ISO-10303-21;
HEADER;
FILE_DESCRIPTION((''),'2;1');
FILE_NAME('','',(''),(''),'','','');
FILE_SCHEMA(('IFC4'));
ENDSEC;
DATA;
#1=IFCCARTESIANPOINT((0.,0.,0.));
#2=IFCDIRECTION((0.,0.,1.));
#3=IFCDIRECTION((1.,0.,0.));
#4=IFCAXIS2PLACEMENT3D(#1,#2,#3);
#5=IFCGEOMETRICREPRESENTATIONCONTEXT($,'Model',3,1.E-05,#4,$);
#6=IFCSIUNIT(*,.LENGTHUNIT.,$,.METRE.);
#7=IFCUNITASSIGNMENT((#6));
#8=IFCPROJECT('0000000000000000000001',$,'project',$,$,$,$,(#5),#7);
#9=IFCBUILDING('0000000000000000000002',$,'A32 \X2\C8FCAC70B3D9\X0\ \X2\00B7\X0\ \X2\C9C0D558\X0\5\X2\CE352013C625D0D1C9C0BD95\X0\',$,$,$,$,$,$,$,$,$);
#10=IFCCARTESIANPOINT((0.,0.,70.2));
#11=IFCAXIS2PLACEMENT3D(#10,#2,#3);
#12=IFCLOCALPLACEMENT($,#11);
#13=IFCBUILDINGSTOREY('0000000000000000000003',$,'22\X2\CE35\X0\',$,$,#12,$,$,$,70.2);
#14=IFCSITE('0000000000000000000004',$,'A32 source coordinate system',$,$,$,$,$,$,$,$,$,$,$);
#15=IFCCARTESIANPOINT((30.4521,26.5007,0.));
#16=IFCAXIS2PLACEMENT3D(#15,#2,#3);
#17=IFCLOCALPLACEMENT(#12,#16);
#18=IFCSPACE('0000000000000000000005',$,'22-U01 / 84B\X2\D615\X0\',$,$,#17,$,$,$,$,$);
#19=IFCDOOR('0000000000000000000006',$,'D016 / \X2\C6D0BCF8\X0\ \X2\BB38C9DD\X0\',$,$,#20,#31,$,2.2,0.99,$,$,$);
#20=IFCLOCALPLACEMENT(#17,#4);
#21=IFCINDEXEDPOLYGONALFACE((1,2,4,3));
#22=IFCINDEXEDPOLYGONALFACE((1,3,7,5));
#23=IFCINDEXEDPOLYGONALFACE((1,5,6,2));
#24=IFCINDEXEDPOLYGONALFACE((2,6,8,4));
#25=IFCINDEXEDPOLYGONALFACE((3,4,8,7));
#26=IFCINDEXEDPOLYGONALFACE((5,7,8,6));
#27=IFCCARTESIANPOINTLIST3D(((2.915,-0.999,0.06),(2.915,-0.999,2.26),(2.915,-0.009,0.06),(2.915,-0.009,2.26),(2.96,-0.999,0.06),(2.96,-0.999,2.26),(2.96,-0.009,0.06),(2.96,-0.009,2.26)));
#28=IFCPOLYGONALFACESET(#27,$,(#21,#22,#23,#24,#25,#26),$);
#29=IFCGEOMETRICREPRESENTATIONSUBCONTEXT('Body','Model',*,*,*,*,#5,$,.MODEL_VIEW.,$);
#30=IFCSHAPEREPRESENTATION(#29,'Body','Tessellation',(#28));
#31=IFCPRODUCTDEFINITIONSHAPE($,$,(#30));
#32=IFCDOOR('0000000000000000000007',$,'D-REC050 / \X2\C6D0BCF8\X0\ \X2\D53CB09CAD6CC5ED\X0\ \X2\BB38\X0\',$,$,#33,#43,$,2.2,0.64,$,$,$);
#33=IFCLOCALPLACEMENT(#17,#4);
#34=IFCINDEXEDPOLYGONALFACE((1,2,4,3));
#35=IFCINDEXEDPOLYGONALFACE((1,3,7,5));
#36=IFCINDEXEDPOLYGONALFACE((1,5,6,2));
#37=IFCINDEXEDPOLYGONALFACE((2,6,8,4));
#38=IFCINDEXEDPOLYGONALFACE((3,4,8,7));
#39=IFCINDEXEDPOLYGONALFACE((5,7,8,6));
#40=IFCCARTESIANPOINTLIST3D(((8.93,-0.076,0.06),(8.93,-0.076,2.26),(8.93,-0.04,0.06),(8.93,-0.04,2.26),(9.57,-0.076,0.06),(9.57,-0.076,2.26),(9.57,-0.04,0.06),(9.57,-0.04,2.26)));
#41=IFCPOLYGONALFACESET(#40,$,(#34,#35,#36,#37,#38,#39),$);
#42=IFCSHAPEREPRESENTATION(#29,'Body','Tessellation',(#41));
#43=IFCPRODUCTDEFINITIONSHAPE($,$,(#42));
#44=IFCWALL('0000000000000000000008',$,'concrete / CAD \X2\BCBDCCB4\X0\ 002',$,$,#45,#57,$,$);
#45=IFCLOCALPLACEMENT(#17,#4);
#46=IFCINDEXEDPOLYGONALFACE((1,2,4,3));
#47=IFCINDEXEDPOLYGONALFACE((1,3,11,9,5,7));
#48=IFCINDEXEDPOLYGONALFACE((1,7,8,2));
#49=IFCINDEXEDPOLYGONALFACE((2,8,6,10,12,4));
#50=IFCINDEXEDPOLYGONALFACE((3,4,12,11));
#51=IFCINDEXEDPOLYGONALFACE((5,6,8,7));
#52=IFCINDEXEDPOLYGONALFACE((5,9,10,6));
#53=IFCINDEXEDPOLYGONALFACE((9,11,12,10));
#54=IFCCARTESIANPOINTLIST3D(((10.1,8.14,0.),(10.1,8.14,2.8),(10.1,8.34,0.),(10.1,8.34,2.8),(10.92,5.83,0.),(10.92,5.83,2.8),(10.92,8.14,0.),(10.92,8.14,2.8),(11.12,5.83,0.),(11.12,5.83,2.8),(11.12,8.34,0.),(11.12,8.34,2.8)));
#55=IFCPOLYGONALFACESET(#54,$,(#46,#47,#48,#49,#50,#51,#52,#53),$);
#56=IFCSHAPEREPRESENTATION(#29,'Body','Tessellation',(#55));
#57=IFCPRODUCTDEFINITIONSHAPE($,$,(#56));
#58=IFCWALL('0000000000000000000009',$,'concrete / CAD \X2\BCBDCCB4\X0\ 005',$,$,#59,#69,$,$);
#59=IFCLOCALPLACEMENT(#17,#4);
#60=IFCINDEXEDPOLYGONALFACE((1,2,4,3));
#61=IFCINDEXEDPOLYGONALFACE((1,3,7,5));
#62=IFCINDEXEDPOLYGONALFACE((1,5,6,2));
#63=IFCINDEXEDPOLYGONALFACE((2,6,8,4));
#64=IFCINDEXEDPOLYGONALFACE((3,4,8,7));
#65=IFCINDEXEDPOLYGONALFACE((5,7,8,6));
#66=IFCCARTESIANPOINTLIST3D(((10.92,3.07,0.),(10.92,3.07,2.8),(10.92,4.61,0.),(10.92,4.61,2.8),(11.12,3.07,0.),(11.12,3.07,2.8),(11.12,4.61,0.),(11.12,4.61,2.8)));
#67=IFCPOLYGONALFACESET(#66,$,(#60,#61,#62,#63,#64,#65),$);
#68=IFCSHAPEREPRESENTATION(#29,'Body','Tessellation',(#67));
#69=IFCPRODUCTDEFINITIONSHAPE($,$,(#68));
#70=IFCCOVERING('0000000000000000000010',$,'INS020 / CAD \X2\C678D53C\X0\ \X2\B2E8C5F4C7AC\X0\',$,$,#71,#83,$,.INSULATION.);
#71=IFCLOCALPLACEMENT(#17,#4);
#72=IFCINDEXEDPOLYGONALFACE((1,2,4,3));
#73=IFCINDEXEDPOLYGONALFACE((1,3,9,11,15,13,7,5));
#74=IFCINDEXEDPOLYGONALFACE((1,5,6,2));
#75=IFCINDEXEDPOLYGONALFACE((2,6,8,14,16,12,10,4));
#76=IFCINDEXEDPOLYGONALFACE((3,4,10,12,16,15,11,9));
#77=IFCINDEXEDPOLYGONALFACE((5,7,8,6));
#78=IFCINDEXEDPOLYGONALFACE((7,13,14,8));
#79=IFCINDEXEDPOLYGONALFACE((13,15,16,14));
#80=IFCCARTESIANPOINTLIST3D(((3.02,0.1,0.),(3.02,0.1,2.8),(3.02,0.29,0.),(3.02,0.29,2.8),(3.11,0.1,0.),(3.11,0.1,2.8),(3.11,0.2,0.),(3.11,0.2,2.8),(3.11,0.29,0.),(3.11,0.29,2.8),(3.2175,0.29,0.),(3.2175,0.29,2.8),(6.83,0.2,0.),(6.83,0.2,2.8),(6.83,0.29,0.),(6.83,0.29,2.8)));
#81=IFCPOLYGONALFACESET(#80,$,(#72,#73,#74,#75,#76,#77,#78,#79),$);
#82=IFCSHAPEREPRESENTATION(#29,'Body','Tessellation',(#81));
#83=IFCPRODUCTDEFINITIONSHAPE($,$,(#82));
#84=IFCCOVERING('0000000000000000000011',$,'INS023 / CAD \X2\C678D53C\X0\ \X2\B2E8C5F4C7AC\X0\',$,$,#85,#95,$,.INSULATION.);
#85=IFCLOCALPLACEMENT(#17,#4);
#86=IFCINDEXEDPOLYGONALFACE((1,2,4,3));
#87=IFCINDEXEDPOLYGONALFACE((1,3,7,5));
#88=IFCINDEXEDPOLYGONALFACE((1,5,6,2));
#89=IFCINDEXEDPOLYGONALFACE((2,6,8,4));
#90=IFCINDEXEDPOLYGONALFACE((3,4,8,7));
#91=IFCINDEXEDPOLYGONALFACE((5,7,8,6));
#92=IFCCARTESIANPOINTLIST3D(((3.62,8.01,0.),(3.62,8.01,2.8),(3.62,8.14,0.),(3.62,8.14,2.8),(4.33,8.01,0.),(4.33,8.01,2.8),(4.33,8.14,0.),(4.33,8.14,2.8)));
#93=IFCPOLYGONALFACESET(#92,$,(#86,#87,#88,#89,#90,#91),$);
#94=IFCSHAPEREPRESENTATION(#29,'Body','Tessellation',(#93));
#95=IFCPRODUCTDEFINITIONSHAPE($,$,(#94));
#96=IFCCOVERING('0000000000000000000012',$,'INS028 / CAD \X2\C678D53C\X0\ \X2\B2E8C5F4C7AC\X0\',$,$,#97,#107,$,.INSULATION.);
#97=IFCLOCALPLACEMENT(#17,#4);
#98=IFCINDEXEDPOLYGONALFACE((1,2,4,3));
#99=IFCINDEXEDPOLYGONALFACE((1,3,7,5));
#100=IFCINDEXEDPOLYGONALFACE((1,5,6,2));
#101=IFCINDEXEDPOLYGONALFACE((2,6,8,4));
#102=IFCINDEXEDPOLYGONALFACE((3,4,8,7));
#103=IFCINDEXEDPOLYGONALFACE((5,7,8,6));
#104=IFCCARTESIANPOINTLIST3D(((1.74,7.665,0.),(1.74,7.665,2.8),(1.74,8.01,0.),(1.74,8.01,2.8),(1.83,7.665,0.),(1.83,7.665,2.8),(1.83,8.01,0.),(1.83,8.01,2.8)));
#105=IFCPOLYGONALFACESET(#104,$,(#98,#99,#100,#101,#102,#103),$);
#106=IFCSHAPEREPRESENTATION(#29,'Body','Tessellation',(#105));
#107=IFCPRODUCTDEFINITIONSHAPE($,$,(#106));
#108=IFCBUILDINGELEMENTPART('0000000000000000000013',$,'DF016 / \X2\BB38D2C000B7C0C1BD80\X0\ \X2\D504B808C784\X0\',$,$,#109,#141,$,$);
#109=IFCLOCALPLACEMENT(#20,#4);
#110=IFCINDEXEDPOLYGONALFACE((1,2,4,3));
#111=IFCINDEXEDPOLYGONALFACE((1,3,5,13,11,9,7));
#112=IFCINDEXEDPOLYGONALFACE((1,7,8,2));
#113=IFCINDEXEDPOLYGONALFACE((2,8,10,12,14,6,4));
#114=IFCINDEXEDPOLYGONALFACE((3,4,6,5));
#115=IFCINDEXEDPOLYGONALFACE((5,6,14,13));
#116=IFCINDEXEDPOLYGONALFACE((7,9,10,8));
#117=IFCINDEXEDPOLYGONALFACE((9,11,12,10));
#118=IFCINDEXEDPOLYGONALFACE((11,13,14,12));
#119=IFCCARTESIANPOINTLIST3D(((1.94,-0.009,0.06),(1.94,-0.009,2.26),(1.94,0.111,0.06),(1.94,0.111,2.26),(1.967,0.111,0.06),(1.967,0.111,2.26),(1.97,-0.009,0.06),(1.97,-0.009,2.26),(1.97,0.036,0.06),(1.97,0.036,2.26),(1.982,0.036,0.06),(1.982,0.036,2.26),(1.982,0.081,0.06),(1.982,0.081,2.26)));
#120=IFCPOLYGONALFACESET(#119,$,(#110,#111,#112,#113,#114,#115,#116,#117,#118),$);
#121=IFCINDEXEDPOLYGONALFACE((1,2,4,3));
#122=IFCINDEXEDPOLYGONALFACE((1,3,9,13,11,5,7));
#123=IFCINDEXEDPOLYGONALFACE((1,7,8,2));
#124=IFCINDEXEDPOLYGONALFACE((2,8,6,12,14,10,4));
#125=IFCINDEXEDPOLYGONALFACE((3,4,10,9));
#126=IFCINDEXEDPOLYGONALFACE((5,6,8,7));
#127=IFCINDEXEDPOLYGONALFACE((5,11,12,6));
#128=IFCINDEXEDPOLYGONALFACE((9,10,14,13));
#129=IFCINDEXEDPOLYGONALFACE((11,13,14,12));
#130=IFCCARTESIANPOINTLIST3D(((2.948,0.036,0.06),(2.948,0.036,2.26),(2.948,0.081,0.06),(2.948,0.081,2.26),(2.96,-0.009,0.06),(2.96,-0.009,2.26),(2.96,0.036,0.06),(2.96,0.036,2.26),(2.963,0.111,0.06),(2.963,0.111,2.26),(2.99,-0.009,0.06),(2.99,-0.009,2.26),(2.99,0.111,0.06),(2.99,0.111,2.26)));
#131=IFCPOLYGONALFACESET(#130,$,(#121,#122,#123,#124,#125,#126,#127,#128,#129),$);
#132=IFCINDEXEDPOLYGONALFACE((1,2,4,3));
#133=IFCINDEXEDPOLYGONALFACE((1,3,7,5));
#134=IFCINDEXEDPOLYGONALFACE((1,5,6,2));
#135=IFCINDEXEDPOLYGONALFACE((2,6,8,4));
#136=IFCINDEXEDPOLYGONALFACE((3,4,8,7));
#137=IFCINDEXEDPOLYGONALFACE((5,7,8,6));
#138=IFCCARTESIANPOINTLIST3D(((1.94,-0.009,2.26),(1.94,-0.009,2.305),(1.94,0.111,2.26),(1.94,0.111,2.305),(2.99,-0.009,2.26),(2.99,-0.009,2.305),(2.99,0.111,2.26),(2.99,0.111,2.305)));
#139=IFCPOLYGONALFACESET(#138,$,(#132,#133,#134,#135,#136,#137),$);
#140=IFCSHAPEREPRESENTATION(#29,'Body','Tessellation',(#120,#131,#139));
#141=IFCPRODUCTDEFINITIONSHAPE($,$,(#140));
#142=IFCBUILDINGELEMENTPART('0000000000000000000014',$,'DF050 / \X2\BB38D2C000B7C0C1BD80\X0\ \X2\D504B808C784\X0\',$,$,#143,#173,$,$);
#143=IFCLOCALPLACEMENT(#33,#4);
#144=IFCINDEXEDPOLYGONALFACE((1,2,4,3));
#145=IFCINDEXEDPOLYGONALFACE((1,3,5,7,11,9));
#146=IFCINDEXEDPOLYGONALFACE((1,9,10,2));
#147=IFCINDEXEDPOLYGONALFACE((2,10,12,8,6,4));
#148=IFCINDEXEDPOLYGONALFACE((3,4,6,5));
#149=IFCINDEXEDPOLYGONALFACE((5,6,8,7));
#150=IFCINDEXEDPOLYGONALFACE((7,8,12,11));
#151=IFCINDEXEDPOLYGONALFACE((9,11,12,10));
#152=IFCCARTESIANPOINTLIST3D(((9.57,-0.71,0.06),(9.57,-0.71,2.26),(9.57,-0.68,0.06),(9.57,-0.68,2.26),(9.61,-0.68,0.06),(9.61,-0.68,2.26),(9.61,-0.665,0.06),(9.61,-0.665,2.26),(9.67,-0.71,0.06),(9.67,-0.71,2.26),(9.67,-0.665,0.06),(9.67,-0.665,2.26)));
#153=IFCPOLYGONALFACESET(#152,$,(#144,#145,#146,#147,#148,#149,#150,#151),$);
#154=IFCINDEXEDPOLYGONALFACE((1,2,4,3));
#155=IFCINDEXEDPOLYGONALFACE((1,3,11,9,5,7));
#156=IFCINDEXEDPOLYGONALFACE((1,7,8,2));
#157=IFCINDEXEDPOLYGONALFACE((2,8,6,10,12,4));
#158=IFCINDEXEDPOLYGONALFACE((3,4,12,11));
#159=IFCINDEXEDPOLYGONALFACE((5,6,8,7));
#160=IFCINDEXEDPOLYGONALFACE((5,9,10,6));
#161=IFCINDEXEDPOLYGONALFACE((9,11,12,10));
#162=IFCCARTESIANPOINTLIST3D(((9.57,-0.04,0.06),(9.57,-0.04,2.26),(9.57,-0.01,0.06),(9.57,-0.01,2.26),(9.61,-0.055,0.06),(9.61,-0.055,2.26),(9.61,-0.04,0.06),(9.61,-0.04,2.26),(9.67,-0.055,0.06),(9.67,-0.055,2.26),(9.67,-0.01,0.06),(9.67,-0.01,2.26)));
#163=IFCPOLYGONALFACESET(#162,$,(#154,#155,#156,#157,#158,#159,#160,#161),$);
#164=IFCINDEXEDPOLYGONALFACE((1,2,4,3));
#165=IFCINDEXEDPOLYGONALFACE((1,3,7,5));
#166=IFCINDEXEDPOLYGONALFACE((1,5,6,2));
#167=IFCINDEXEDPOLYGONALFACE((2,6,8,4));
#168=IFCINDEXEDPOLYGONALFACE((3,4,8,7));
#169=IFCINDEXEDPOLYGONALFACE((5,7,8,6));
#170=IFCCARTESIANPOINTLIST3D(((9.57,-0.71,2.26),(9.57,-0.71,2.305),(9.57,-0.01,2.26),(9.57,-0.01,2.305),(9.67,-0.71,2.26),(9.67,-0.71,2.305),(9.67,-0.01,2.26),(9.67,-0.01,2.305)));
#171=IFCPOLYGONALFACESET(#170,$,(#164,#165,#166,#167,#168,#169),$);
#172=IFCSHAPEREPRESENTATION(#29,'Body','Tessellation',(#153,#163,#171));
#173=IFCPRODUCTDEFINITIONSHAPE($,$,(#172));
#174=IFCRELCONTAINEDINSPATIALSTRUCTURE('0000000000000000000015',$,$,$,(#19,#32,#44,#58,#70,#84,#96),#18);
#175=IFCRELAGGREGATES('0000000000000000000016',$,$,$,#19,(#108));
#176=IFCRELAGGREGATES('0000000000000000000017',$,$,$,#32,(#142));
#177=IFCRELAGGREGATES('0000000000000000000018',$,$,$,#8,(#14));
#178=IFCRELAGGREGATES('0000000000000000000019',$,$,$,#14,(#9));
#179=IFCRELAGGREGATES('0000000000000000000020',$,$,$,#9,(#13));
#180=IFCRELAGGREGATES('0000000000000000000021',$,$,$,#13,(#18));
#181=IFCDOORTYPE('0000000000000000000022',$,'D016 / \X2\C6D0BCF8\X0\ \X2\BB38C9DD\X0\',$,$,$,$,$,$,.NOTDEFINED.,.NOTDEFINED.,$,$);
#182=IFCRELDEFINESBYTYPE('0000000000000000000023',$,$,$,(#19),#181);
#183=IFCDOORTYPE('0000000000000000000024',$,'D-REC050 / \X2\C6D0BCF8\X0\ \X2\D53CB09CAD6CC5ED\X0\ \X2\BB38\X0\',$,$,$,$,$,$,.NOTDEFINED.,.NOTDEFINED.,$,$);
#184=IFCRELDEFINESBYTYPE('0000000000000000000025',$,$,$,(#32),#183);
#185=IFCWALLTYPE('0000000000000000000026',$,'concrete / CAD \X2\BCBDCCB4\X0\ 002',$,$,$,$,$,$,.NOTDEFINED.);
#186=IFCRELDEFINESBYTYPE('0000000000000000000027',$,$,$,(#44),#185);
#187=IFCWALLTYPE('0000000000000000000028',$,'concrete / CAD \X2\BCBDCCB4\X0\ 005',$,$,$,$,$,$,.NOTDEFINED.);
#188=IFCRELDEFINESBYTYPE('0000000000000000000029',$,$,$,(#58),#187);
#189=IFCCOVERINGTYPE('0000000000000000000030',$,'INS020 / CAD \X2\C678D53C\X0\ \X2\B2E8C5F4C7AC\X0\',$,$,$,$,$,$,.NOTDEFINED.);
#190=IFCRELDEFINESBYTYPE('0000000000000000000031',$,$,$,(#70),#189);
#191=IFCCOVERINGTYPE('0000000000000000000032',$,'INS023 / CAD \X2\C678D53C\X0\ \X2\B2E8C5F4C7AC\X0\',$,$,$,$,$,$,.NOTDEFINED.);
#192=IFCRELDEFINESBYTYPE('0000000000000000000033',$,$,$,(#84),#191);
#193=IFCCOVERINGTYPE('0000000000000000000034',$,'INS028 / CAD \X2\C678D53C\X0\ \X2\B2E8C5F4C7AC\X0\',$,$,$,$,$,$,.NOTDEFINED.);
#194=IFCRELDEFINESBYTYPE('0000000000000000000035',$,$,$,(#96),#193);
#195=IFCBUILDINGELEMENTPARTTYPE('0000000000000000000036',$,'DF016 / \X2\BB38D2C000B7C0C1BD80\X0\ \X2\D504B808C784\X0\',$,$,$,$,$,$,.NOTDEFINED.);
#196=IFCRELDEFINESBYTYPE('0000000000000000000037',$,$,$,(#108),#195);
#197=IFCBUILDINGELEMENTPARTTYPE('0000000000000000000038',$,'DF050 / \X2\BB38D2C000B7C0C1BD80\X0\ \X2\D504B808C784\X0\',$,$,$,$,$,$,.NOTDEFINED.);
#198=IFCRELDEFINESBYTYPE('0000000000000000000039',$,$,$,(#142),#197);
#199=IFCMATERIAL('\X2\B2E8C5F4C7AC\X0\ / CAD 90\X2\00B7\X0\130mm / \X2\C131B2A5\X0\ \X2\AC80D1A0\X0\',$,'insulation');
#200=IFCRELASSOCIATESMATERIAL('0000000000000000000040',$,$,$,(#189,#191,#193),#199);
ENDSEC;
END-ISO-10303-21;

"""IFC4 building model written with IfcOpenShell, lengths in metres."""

from ifc_helpers import new_model, si_unit, frame, origin, origin_with_axes, place, context, subcontext, project, spatial, polyline, outline, extrude, source, transform, mapped, material, type_object, type_shapes, element, aggregate, save


model = new_model("IFC4")

# Units and contexts
model_context = context("Model", 3, precision=1e-05, world=origin_with_axes())
body_context = subcontext(model_context, "Body", "Model", "MODEL_VIEW")
ifc_project = project(units=[si_unit("LENGTHUNIT", "METRE")], contexts=[model_context])

# Site, building, storey, space
storey_placement = place(None, frame((0.0, 0.0, 70.2), z_axis=(0.0, 0.0, 1.0), x_axis=(1.0, 0.0, 0.0)))
space_placement = place(storey_placement, frame((30.4521, 26.5007, 0.0), z_axis=(0.0, 0.0, 1.0), x_axis=(1.0, 0.0, 0.0)))
site = spatial("IfcSite", under=ifc_project, Name="A32 source coordinate system")
building = spatial("IfcBuilding", under=site, Name="A32 주거동 · 지하5층–옥탑지붕")
storey = spatial("IfcBuildingStorey", under=building, at=storey_placement, Name="22층", Elevation=70.2)
space = spatial("IfcSpace", under=storey, at=space_placement, Name="22-U01 / 84B형")

# Doors
door_type_1 = type_object("IfcDoorType", Name="D016 / 원본 문짝", OperationType="NOTDEFINED", PredefinedType="NOTDEFINED")
shared_shape_1 = source(origin(), body_context, "Body", "SweptSolid", [
    extrude(outline(polyline([(2.96, -0.009), (2.96, -0.999), (2.915, -0.999), (2.915, -0.009), (2.96, -0.009)])), frame((0.0, 0.0, 0.06)), (0.0, 0.0, 1.0), 2.2),
])
type_shapes(door_type_1, [shared_shape_1])
door_1_placement = place(space_placement, origin_with_axes())
door_1 = element("IfcDoor", 1, at=door_1_placement, inside=space, type_object=door_type_1, Name="D016 / 원본 문짝", OverallHeight=2.2, OverallWidth=0.99, context=body_context, shape_type="MappedRepresentation", body=[
    mapped(shared_shape_1, transform((0.0, 0.0, 0.0), scale=1.0)),
])
door_type_2 = type_object("IfcDoorType", Name="D-REC050 / 원본 피난구역 문", OperationType="NOTDEFINED", PredefinedType="NOTDEFINED")
shared_shape_2 = source(origin(), body_context, "Body", "SweptSolid", [
    extrude(outline(polyline([(9.57, -0.04), (9.57, -0.076), (8.93, -0.076), (8.93, -0.04), (9.57, -0.04)])), frame((0.0, 0.0, 0.06)), (0.0, 0.0, 1.0), 2.2),
])
type_shapes(door_type_2, [shared_shape_2])
door_2_placement = place(space_placement, origin_with_axes())
door_2 = element("IfcDoor", 2, at=door_2_placement, inside=space, type_object=door_type_2, Name="D-REC050 / 원본 피난구역 문", OverallHeight=2.2, OverallWidth=0.64, context=body_context, shape_type="MappedRepresentation", body=[
    mapped(shared_shape_2, transform((0.0, 0.0, 0.0), scale=1.0)),
])

# Walls
wall_type_1 = type_object("IfcWallType", Name="concrete / CAD 벽체 002", PredefinedType="NOTDEFINED")
shared_shape_3 = source(origin(), body_context, "Body", "SweptSolid", [
    extrude(outline(polyline([(11.12, 5.83), (10.92, 5.83), (10.92, 8.14), (10.1, 8.14), (10.1, 8.34), (11.12, 8.34), (11.12, 5.83)])), origin(), (0.0, 0.0, 1.0), 2.8),
])
type_shapes(wall_type_1, [shared_shape_3])
wall_1_placement = place(space_placement, origin_with_axes())
element("IfcWall", 3, at=wall_1_placement, inside=space, type_object=wall_type_1, Name="concrete / CAD 벽체 002", context=body_context, shape_type="MappedRepresentation", body=[
    mapped(shared_shape_3, transform((0.0, 0.0, 0.0), scale=1.0)),
])
wall_type_2 = type_object("IfcWallType", Name="concrete / CAD 벽체 005", PredefinedType="NOTDEFINED")
shared_shape_4 = source(origin(), body_context, "Body", "SweptSolid", [
    extrude(outline(polyline([(11.12, 3.07), (10.92, 3.07), (10.92, 4.61), (11.12, 4.61), (11.12, 3.07)])), origin(), (0.0, 0.0, 1.0), 2.8),
])
type_shapes(wall_type_2, [shared_shape_4])
wall_2_placement = place(space_placement, origin_with_axes())
element("IfcWall", 4, at=wall_2_placement, inside=space, type_object=wall_type_2, Name="concrete / CAD 벽체 005", context=body_context, shape_type="MappedRepresentation", body=[
    mapped(shared_shape_4, transform((0.0, 0.0, 0.0), scale=1.0)),
])

# Coverings
ifc_material = material(Name="단열재 / CAD 90·130mm / 성능 검토", Category="insulation")
covering_type_1 = type_object("IfcCoveringType", Name="INS020 / CAD 외피 단열재", PredefinedType="NOTDEFINED", material=ifc_material)
shared_shape_5 = source(origin(), body_context, "Body", "SweptSolid", [
    extrude(outline(polyline([(3.11, 0.2), (3.11, 0.1), (3.02, 0.1), (3.02, 0.29), (3.11, 0.29), (3.2175, 0.29), (6.83, 0.29), (6.83, 0.2), (3.11, 0.2)])), origin(), (0.0, 0.0, 1.0), 2.8),
])
type_shapes(covering_type_1, [shared_shape_5])
covering_1_placement = place(space_placement, origin_with_axes())
element("IfcCovering", 5, at=covering_1_placement, inside=space, type_object=covering_type_1, Name="INS020 / CAD 외피 단열재", PredefinedType="INSULATION", context=body_context, shape_type="MappedRepresentation", body=[
    mapped(shared_shape_5, transform((0.0, 0.0, 0.0), scale=1.0)),
])
covering_type_2 = type_object("IfcCoveringType", Name="INS023 / CAD 외피 단열재", PredefinedType="NOTDEFINED", material=ifc_material)
shared_shape_6 = source(origin(), body_context, "Body", "SweptSolid", [
    extrude(outline(polyline([(4.33, 8.01), (3.62, 8.01), (3.62, 8.14), (4.33, 8.14), (4.33, 8.01)])), origin(), (0.0, 0.0, 1.0), 2.8),
])
type_shapes(covering_type_2, [shared_shape_6])
covering_2_placement = place(space_placement, origin_with_axes())
element("IfcCovering", 6, at=covering_2_placement, inside=space, type_object=covering_type_2, Name="INS023 / CAD 외피 단열재", PredefinedType="INSULATION", context=body_context, shape_type="MappedRepresentation", body=[
    mapped(shared_shape_6, transform((0.0, 0.0, 0.0), scale=1.0)),
])
covering_type_3 = type_object("IfcCoveringType", Name="INS028 / CAD 외피 단열재", PredefinedType="NOTDEFINED", material=ifc_material)
shared_shape_7 = source(origin(), body_context, "Body", "SweptSolid", [
    extrude(outline(polyline([(1.74, 8.01), (1.83, 8.01), (1.83, 7.665), (1.74, 7.665), (1.74, 8.01)])), origin(), (0.0, 0.0, 1.0), 2.8),
])
type_shapes(covering_type_3, [shared_shape_7])
covering_3_placement = place(space_placement, origin_with_axes())
element("IfcCovering", 7, at=covering_3_placement, inside=space, type_object=covering_type_3, Name="INS028 / CAD 외피 단열재", PredefinedType="INSULATION", context=body_context, shape_type="MappedRepresentation", body=[
    mapped(shared_shape_7, transform((0.0, 0.0, 0.0), scale=1.0)),
])

# Building element parts
building_element_part_type_1 = type_object("IfcBuildingElementPartType", Name="DF016 / 문틀·상부 프레임", PredefinedType="NOTDEFINED")
shared_shape_8 = source(origin(), body_context, "Body", "SweptSolid", [
    extrude(outline(polyline([(1.94, 0.111), (1.967, 0.111), (1.982, 0.081), (1.982, 0.036), (1.97, 0.036), (1.97, -0.009), (1.94, -0.009), (1.94, 0.111)])), frame((0.0, 0.0, 0.06)), (0.0, 0.0, 1.0), 2.2),
    extrude(outline(polyline([(2.96, -0.009), (2.96, 0.036), (2.948, 0.036), (2.948, 0.081), (2.963, 0.111), (2.99, 0.111), (2.99, -0.009), (2.96, -0.009)])), frame((0.0, 0.0, 0.06)), (0.0, 0.0, 1.0), 2.2),
    extrude(outline(polyline([(1.94, -0.009), (1.94, 0.111), (2.99, 0.111), (2.99, -0.009), (1.94, -0.009)])), frame((0.0, 0.0, 2.26)), (0.0, 0.0, 1.0), 0.045),
])
type_shapes(building_element_part_type_1, [shared_shape_8])
building_element_part_1_placement = place(door_1_placement, origin_with_axes())
building_element_part_1 = element("IfcBuildingElementPart", 8, at=building_element_part_1_placement, type_object=building_element_part_type_1, Name="DF016 / 문틀·상부 프레임", context=body_context, shape_type="MappedRepresentation", body=[
    mapped(shared_shape_8, transform((0.0, 0.0, 0.0), scale=1.0)),
])
aggregate(door_1, [building_element_part_1])
building_element_part_type_2 = type_object("IfcBuildingElementPartType", Name="DF050 / 문틀·상부 프레임", PredefinedType="NOTDEFINED")
shared_shape_9 = source(origin(), body_context, "Body", "SweptSolid", [
    extrude(outline(polyline([(9.57, -0.68), (9.61, -0.68), (9.61, -0.665), (9.67, -0.665), (9.67, -0.71), (9.57, -0.71), (9.57, -0.68)])), frame((0.0, 0.0, 0.06)), (0.0, 0.0, 1.0), 2.2),
    extrude(outline(polyline([(9.67, -0.01), (9.67, -0.055), (9.61, -0.055), (9.61, -0.04), (9.57, -0.04), (9.57, -0.01), (9.67, -0.01)])), frame((0.0, 0.0, 0.06)), (0.0, 0.0, 1.0), 2.2),
    extrude(outline(polyline([(9.57, -0.71), (9.57, -0.01), (9.67, -0.01), (9.67, -0.71), (9.57, -0.71)])), frame((0.0, 0.0, 2.26)), (0.0, 0.0, 1.0), 0.045),
])
type_shapes(building_element_part_type_2, [shared_shape_9])
building_element_part_2_placement = place(door_2_placement, origin_with_axes())
building_element_part_2 = element("IfcBuildingElementPart", 9, at=building_element_part_2_placement, type_object=building_element_part_type_2, Name="DF050 / 문틀·상부 프레임", context=body_context, shape_type="MappedRepresentation", body=[
    mapped(shared_shape_9, transform((0.0, 0.0, 0.0), scale=1.0)),
])
aggregate(door_2, [building_element_part_2])

save(model, "model.ifc")
